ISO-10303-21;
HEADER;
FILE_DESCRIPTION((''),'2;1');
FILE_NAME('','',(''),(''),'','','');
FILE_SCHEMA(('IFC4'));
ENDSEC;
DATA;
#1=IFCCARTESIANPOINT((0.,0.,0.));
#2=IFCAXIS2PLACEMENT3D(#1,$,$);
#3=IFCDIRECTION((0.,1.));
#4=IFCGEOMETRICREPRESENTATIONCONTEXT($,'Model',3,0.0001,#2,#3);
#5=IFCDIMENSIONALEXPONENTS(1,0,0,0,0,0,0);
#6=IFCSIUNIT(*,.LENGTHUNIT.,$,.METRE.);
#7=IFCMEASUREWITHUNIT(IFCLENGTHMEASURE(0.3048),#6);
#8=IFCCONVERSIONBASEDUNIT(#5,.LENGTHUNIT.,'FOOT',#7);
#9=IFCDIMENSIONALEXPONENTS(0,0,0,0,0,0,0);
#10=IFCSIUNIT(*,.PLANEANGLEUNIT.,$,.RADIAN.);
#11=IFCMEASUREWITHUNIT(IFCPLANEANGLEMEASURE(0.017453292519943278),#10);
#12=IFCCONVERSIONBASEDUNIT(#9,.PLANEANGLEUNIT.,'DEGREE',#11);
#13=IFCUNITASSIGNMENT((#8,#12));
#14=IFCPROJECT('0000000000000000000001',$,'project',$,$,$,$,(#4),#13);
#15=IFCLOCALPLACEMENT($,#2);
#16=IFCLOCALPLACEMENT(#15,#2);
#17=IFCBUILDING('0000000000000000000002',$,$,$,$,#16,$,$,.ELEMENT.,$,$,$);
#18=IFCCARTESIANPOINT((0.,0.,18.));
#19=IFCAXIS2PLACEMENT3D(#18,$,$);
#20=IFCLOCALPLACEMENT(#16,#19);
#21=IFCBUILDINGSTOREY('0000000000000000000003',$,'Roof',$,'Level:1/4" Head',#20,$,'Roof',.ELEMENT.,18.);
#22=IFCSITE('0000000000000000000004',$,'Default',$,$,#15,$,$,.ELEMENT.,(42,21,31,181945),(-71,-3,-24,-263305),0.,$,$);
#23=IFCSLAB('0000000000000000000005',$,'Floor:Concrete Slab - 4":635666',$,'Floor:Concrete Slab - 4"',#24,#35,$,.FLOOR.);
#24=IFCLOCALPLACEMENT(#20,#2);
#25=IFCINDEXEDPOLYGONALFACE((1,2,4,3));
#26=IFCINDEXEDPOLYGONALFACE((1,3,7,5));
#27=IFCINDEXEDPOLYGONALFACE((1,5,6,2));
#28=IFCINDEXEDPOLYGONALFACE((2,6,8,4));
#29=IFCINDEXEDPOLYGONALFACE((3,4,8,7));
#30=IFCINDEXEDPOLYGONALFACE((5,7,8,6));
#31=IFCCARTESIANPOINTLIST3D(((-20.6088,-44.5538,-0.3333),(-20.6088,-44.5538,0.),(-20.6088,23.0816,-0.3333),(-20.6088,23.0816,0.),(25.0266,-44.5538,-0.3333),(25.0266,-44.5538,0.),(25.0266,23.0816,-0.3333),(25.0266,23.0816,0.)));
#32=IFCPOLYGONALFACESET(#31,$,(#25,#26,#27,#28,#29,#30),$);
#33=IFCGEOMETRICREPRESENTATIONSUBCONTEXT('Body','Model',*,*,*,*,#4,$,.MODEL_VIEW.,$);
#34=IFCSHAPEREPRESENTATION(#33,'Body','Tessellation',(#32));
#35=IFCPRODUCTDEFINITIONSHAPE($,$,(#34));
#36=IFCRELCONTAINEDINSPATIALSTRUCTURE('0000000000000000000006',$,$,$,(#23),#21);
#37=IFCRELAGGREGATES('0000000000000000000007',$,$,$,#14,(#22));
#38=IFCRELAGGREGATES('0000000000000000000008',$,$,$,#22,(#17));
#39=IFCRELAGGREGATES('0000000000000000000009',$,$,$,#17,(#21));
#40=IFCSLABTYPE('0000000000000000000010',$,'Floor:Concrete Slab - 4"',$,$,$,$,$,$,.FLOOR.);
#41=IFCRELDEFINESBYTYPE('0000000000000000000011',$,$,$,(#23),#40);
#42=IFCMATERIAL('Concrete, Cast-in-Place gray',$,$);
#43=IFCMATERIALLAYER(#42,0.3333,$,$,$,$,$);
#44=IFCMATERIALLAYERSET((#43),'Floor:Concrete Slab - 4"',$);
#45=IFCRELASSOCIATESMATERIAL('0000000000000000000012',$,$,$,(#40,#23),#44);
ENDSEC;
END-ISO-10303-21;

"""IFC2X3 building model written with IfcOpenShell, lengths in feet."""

from ifc_helpers import new_model, entity, si_unit, converted_unit, direction, frame, frame_2d, origin, place, context, subcontext, project, spatial, rectangle, extrude, material, layer, layer_set, layer_usage, type_object, element, save


model = new_model("IFC2X3")

# Units and contexts
model_context = context("Model", 3, precision=0.0001, world=origin(), true_north=direction((0.0, 1.0)))
body_context = subcontext(model_context, "Body", "Model", "MODEL_VIEW")
ifc_project = project(units=[converted_unit("LENGTHUNIT", "FOOT", entity("IfcLengthMeasure", 0.3048), si_unit("LENGTHUNIT", "METRE"), dimensions=[1, 0, 0, 0, 0, 0, 0]), converted_unit("PLANEANGLEUNIT", "DEGREE", entity("IfcPlaneAngleMeasure", 0.017453292519943278), si_unit("PLANEANGLEUNIT", "RADIAN"), dimensions=[0, 0, 0, 0, 0, 0, 0])], contexts=[model_context])

# Site, building, storey
site_placement = place(None, origin())
site = spatial("IfcSite", under=ifc_project, at=site_placement, Name="Default", CompositionType="ELEMENT", RefLatitude=(42, 21, 31, 181945), RefLongitude=(-71, -3, -24, -263305), RefElevation=0.0)
building_placement = place(site_placement, origin())
building = spatial("IfcBuilding", under=site, at=building_placement, CompositionType="ELEMENT")
storey_placement = place(building_placement, frame((0.0, 0.0, 18.0)))
storey = spatial("IfcBuildingStorey", under=building, at=storey_placement, Name="Roof", ObjectType="Level:1/4\" Head", LongName="Roof", CompositionType="ELEMENT", Elevation=18.0)

# Slab
ifc_material = material(Name="Concrete, Cast-in-Place gray")
ifc_layer = layer(ifc_material, 0.3333)
ifc_layer_set = layer_set([ifc_layer], Name="Floor:Concrete Slab - 4\"")
ifc_layer_usage = layer_usage(ifc_layer_set, "AXIS3", "POSITIVE", 0.0)
slab_type = type_object("IfcSlabType", Name="Floor:Concrete Slab - 4\"", PredefinedType="FLOOR", material=ifc_layer_set)
slab_placement = place(storey_placement, origin())
element("IfcSlab", 1, at=slab_placement, inside=storey, type_object=slab_type, material=ifc_layer_usage, Name="Floor:Concrete Slab - 4\":635666", ObjectType="Floor:Concrete Slab - 4\"", PredefinedType="FLOOR", context=body_context, shape_type="SweptSolid", body=[
    extrude(rectangle(XDim=67.6354, YDim=45.6354, at=frame_2d((0.0, 0.0), x_axis=(1.0, 0.0))), frame((2.2089, -10.7361, 0.0), z_axis=(0.0, 0.0, -1.0), x_axis=(0.0, 1.0, 0.0)), (0.0, 0.0, 1.0), 0.3333),
])

save(model, "model.ifc")
